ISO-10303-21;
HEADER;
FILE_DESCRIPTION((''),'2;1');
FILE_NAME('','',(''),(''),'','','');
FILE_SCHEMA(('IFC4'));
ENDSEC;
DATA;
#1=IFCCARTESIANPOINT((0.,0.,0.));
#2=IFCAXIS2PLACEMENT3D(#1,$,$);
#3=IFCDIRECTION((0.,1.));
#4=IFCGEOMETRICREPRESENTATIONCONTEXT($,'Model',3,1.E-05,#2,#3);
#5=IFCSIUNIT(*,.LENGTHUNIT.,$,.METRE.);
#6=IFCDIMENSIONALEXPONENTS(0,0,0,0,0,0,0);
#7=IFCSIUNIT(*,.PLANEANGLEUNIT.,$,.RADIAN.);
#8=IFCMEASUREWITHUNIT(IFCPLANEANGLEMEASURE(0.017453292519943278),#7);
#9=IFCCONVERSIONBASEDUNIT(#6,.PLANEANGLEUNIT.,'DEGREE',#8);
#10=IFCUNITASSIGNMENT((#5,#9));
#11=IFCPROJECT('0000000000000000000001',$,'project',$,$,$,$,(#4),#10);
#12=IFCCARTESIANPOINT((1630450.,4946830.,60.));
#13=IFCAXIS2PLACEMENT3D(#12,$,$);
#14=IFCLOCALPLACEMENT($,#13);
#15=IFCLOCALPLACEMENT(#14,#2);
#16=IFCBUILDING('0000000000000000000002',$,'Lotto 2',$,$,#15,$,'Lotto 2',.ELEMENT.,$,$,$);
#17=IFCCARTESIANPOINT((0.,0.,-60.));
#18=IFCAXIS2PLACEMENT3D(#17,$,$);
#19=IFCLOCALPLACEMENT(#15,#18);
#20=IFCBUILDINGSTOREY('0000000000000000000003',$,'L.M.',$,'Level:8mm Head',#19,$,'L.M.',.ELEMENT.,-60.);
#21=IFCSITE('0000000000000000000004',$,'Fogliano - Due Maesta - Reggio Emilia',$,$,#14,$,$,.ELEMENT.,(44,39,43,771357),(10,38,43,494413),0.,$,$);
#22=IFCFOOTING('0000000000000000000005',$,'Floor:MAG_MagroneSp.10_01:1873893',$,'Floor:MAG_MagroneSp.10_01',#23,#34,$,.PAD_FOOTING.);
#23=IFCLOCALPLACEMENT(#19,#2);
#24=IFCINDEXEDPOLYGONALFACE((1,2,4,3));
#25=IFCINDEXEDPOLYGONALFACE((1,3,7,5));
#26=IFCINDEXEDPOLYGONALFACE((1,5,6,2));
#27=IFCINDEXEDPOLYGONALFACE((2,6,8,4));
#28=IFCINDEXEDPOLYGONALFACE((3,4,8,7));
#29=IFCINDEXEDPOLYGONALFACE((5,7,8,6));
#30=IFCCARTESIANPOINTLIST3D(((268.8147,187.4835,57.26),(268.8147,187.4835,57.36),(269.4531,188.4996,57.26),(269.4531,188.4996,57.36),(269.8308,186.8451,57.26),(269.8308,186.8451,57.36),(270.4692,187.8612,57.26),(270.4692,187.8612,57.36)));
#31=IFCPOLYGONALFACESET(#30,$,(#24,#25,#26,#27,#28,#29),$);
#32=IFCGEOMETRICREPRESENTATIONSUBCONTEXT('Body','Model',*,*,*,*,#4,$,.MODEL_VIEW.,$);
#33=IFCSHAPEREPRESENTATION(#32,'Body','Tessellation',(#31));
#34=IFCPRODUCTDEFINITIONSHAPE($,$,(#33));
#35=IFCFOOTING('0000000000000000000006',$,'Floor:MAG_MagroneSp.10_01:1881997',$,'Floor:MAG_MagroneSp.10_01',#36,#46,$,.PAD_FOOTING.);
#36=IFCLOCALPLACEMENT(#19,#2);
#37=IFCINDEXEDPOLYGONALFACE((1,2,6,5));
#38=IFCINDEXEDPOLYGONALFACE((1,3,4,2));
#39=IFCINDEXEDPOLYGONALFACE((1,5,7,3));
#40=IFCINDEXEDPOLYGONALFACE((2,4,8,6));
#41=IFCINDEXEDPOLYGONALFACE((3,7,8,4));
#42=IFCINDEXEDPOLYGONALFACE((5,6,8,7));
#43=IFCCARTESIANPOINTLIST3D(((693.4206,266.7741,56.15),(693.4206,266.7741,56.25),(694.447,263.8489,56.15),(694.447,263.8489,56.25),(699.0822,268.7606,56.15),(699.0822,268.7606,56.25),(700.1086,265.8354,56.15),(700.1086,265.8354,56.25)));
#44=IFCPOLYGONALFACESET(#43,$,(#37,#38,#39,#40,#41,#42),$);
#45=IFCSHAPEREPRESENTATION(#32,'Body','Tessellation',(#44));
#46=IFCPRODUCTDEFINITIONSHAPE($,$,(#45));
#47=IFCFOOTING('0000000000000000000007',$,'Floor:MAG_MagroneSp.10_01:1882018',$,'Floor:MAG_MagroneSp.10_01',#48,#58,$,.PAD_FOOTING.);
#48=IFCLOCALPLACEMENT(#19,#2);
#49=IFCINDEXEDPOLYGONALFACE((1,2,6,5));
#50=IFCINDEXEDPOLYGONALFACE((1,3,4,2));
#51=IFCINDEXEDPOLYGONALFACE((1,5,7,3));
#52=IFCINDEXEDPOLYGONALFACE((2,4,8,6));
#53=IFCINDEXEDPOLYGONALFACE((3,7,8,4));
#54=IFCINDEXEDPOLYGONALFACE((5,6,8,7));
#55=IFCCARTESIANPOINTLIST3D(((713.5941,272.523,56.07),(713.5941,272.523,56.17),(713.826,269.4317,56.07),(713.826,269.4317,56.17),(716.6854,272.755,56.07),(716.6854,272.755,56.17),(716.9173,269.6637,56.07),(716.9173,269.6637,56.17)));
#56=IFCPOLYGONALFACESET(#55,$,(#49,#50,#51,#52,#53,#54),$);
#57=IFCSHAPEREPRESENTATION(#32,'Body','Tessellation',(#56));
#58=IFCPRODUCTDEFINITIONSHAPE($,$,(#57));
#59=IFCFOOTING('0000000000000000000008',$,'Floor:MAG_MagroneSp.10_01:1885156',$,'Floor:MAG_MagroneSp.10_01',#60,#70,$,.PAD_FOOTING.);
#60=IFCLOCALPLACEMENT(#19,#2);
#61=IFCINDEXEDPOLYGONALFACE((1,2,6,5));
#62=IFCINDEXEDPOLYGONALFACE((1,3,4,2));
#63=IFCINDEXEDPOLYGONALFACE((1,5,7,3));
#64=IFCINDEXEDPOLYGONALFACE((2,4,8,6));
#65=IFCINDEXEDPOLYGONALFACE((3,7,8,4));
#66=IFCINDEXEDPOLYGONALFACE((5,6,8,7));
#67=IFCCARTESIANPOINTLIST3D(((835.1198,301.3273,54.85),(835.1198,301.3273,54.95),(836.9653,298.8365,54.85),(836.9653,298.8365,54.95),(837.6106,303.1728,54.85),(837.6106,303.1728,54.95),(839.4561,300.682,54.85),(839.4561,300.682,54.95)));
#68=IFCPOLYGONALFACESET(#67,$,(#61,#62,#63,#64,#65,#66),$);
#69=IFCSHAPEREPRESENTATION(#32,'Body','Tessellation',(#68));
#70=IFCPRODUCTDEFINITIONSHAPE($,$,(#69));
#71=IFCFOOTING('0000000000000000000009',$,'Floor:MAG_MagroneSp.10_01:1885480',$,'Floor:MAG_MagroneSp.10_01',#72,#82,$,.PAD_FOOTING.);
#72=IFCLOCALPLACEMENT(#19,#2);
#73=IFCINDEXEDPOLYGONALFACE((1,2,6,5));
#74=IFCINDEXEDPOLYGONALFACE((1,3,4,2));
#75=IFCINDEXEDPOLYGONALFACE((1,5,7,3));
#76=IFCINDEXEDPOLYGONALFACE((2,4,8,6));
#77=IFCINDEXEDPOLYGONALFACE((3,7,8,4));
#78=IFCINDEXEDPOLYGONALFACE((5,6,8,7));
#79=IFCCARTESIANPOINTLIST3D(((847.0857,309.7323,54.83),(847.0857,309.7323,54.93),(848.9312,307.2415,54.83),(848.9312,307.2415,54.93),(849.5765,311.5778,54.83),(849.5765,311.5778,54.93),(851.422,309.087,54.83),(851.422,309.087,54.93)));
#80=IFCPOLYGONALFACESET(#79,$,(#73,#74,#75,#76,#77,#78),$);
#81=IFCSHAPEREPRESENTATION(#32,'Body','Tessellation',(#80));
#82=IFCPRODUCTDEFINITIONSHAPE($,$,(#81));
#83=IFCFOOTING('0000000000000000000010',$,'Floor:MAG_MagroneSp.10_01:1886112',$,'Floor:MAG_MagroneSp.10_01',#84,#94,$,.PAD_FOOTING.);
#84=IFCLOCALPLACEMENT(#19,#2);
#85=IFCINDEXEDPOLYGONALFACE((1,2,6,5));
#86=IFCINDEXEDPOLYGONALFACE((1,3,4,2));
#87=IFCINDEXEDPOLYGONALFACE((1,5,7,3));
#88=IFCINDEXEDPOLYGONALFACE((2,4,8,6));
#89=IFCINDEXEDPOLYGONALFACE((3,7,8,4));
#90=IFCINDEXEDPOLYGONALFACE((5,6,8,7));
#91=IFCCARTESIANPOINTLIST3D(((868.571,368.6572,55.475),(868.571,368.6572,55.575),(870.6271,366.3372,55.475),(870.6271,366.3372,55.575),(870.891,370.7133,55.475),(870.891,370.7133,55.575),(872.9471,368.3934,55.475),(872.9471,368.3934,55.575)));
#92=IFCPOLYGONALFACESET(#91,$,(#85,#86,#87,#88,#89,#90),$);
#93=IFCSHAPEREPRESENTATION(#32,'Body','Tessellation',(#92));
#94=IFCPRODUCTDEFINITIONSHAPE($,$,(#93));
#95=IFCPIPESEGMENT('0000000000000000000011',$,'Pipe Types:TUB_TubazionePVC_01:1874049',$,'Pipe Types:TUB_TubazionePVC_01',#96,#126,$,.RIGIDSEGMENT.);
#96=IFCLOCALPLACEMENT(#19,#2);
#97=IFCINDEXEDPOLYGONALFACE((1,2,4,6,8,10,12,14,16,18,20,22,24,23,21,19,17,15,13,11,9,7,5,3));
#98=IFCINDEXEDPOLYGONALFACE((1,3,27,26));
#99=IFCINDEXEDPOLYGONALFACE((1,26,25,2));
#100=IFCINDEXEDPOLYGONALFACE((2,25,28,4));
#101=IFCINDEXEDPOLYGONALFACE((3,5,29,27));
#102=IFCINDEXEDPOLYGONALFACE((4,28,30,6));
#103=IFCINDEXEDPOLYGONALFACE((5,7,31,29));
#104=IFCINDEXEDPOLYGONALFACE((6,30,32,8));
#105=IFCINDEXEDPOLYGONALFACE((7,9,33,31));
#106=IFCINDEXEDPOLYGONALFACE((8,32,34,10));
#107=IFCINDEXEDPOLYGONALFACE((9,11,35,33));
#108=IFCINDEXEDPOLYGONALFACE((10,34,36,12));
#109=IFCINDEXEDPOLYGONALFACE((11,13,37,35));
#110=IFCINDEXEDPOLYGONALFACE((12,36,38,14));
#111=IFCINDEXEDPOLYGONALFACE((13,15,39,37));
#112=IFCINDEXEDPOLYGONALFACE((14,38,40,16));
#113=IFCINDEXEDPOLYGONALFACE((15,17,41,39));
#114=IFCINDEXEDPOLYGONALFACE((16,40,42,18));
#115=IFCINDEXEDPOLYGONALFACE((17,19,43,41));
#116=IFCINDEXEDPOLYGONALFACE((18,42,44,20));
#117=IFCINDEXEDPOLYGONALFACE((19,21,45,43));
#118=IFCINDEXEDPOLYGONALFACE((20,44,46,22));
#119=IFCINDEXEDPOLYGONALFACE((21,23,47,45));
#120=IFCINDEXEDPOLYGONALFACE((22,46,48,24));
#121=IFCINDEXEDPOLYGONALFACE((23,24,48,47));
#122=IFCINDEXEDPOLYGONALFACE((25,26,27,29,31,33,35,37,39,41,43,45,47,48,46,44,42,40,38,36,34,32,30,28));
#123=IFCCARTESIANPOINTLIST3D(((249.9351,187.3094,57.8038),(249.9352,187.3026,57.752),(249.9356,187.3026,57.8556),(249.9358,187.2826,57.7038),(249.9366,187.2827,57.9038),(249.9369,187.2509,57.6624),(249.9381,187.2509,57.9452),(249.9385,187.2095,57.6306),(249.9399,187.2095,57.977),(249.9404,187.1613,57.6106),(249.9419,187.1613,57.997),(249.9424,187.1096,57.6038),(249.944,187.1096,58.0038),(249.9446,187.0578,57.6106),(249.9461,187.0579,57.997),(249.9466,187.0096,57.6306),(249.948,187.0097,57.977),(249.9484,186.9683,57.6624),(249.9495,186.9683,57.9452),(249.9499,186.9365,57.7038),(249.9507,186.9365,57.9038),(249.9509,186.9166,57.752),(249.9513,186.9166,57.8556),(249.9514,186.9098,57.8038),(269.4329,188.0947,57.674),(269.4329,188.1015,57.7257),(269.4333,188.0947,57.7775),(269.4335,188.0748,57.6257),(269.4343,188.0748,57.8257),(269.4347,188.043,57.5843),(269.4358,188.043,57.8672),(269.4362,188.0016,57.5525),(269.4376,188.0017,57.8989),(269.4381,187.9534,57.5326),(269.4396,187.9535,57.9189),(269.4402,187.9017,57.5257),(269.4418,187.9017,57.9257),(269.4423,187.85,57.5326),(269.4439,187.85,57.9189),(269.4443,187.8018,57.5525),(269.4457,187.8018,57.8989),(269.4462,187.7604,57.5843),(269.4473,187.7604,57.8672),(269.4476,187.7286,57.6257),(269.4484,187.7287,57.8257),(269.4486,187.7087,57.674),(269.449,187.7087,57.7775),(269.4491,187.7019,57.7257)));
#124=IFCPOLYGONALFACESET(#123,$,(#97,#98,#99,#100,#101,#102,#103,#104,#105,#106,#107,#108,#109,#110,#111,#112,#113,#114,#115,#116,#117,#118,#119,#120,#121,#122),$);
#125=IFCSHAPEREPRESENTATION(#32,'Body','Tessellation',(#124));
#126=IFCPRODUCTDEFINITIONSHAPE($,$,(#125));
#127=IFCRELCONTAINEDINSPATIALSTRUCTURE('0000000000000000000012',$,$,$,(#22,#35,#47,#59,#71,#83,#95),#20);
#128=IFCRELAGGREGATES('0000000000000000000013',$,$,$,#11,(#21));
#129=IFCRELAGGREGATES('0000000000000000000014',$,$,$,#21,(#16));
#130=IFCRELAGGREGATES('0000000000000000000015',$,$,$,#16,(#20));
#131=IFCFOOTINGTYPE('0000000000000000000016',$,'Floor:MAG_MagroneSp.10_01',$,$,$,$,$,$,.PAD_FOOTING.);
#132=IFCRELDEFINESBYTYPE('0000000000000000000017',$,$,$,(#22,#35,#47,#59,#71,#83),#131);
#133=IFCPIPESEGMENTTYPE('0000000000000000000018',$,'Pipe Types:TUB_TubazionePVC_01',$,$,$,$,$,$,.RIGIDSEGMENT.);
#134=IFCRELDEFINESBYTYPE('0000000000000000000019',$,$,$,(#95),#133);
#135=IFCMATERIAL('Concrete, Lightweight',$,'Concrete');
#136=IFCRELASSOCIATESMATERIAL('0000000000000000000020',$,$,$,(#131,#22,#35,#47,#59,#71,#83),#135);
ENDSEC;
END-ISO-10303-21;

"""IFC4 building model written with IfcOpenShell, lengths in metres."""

from ifc_helpers import new_model, entity, si_unit, converted_unit, direction, frame, origin, place, context, subcontext, project, spatial, arc, indexed_curve, outline, extrude, material, type_object, element, save


model = new_model("IFC4")

# Units and contexts
model_context = context("Model", 3, precision=1e-05, world=origin(), true_north=direction((0.0, 1.0)))
body_context = subcontext(model_context, "Body", "Model", "MODEL_VIEW")
ifc_project = project(units=[si_unit("LENGTHUNIT", "METRE"), converted_unit("PLANEANGLEUNIT", "DEGREE", entity("IfcPlaneAngleMeasure", 0.017453292519943278), si_unit("PLANEANGLEUNIT", "RADIAN"), dimensions=[0, 0, 0, 0, 0, 0, 0])], contexts=[model_context])

# Site, building, storey
site_placement = place(None, frame((1630450.0, 4946830.0, 60.0)))
site = spatial("IfcSite", under=ifc_project, at=site_placement, Name="Fogliano - Due Maesta - Reggio Emilia", CompositionType="ELEMENT", RefLatitude=(44, 39, 43, 771357), RefLongitude=(10, 38, 43, 494413), RefElevation=0.0)
building_placement = place(site_placement, origin())
building = spatial("IfcBuilding", under=site, at=building_placement, Name="Lotto 2", LongName="Lotto 2", CompositionType="ELEMENT")
storey_placement = place(building_placement, frame((0.0, 0.0, -60.0)))
storey = spatial("IfcBuildingStorey", under=building, at=storey_placement, Name="L.M.", ObjectType="Level:8mm Head", LongName="L.M.", CompositionType="ELEMENT", Elevation=-60.0)

# Footings
ifc_material = material(Name="Concrete, Lightweight", Category="Concrete")
footing_type = type_object("IfcFootingType", Name="Floor:MAG_MagroneSp.10_01", PredefinedType="PAD_FOOTING", material=ifc_material)
footing_1_placement = place(storey_placement, origin())
element("IfcFooting", 1, at=footing_1_placement, inside=storey, type_object=footing_type, material=ifc_material, Name="Floor:MAG_MagroneSp.10_01:1873893", ObjectType="Floor:MAG_MagroneSp.10_01", PredefinedType="PAD_FOOTING", context=body_context, shape_type="SweptSolid", body=[
    extrude(outline(indexed_curve([(-0.6, -0.6), (0.6, -0.6), (0.6, 0.6), (-0.6, 0.6), (-0.6, -0.6)], self_intersect=False)), frame((269.642, 187.6724, 57.36), z_axis=(0.0, 0.0, -1.0), x_axis=(-0.532003, -0.846743, 0.0)), (0.0, 0.0, 1.0), 0.1),
])
footing_2_placement = place(storey_placement, origin())
element("IfcFooting", 2, at=footing_2_placement, inside=storey, type_object=footing_type, material=ifc_material, Name="Floor:MAG_MagroneSp.10_01:1881997", ObjectType="Floor:MAG_MagroneSp.10_01", PredefinedType="PAD_FOOTING", context=body_context, shape_type="SweptSolid", body=[
    extrude(outline(indexed_curve([(-3.0, -1.55), (3.0, -1.55), (3.0, 1.55), (-3.0, 1.55), (-3.0, -1.55)], self_intersect=False)), frame((696.7646, 266.3048, 56.25), z_axis=(0.0, 0.0, -1.0), x_axis=(0.943601, 0.331086, 0.0)), (0.0, 0.0, 1.0), 0.1),
])
footing_3_placement = place(storey_placement, origin())
element("IfcFooting", 3, at=footing_3_placement, inside=storey, type_object=footing_type, material=ifc_material, Name="Floor:MAG_MagroneSp.10_01:1882018", ObjectType="Floor:MAG_MagroneSp.10_01", PredefinedType="PAD_FOOTING", context=body_context, shape_type="SweptSolid", body=[
    extrude(outline(indexed_curve([(-1.55, -1.55), (1.55, -1.55), (1.55, 1.55), (-1.55, 1.55), (-1.55, -1.55)], self_intersect=False)), frame((715.2557, 271.0934, 56.17), z_axis=(0.0, 0.0, -1.0), x_axis=(0.997197, 0.074817, 0.0)), (0.0, 0.0, 1.0), 0.1),
])
footing_4_placement = place(storey_placement, origin())
element("IfcFooting", 4, at=footing_4_placement, inside=storey, type_object=footing_type, material=ifc_material, Name="Floor:MAG_MagroneSp.10_01:1885156", ObjectType="Floor:MAG_MagroneSp.10_01", PredefinedType="PAD_FOOTING", context=body_context, shape_type="SweptSolid", body=[
    extrude(outline(indexed_curve([(-1.55, -1.55), (1.55, -1.55), (1.55, 1.55), (-1.55, 1.55), (-1.55, -1.55)], self_intersect=False)), frame((837.2879, 301.0047, 54.95), z_axis=(0.0, 0.0, -1.0), x_axis=(0.595325, -0.803485, 0.0)), (0.0, 0.0, 1.0), 0.1),
])
footing_5_placement = place(storey_placement, origin())
element("IfcFooting", 5, at=footing_5_placement, inside=storey, type_object=footing_type, material=ifc_material, Name="Floor:MAG_MagroneSp.10_01:1885480", ObjectType="Floor:MAG_MagroneSp.10_01", PredefinedType="PAD_FOOTING", context=body_context, shape_type="SweptSolid", body=[
    extrude(outline(indexed_curve([(-1.55, -1.55), (1.55, -1.55), (1.55, 1.55), (-1.55, 1.55), (-1.55, -1.55)], self_intersect=False)), frame((849.2538, 309.4097, 54.93), z_axis=(0.0, 0.0, -1.0), x_axis=(0.595325, -0.803485, 0.0)), (0.0, 0.0, 1.0), 0.1),
])
footing_6_placement = place(storey_placement, origin())
element("IfcFooting", 6, at=footing_6_placement, inside=storey, type_object=footing_type, material=ifc_material, Name="Floor:MAG_MagroneSp.10_01:1886112", ObjectType="Floor:MAG_MagroneSp.10_01", PredefinedType="PAD_FOOTING", context=body_context, shape_type="SweptSolid", body=[
    extrude(outline(indexed_curve([(-1.55, -1.55), (1.55, -1.55), (1.55, 1.55), (-1.55, 1.55), (-1.55, -1.55)], self_intersect=False)), frame((870.7591, 368.5253, 55.575), z_axis=(0.0, 0.0, -1.0), x_axis=(0.663271, -0.748379, 0.0)), (0.0, 0.0, 1.0), 0.1),
])

# Pipe segment
pipe_segment_type = type_object("IfcPipeSegmentType", Name="Pipe Types:TUB_TubazionePVC_01", PredefinedType="RIGIDSEGMENT")
pipe_segment_placement = place(storey_placement, origin())
element("IfcPipeSegment", 7, at=pipe_segment_placement, inside=storey, type_object=pipe_segment_type, Name="Pipe Types:TUB_TubazionePVC_01:1874049", ObjectType="Pipe Types:TUB_TubazionePVC_01", PredefinedType="RIGIDSEGMENT", context=body_context, shape_type="SweptSolid", body=[
    extrude(outline(indexed_curve([(0.2, 0.0), (0.1414, 0.1414), (0.0, 0.2), (-0.1414, 0.1414), (-0.2, 0.0), (-0.1414, -0.1414), (0.0, -0.2), (0.1414, -0.1414)], segments=[arc(1, 2, 3), arc(3, 4, 5), arc(5, 6, 7), arc(7, 8, 1)], self_intersect=False)), frame((249.9432, 187.1096, 57.8038), z_axis=(0.999168, 0.040593, -0.004), x_axis=(0.040593, -0.999176, 0.0)), (0.0, 0.0, 1.0), 19.514),
])

save(model, "model.ifc")
